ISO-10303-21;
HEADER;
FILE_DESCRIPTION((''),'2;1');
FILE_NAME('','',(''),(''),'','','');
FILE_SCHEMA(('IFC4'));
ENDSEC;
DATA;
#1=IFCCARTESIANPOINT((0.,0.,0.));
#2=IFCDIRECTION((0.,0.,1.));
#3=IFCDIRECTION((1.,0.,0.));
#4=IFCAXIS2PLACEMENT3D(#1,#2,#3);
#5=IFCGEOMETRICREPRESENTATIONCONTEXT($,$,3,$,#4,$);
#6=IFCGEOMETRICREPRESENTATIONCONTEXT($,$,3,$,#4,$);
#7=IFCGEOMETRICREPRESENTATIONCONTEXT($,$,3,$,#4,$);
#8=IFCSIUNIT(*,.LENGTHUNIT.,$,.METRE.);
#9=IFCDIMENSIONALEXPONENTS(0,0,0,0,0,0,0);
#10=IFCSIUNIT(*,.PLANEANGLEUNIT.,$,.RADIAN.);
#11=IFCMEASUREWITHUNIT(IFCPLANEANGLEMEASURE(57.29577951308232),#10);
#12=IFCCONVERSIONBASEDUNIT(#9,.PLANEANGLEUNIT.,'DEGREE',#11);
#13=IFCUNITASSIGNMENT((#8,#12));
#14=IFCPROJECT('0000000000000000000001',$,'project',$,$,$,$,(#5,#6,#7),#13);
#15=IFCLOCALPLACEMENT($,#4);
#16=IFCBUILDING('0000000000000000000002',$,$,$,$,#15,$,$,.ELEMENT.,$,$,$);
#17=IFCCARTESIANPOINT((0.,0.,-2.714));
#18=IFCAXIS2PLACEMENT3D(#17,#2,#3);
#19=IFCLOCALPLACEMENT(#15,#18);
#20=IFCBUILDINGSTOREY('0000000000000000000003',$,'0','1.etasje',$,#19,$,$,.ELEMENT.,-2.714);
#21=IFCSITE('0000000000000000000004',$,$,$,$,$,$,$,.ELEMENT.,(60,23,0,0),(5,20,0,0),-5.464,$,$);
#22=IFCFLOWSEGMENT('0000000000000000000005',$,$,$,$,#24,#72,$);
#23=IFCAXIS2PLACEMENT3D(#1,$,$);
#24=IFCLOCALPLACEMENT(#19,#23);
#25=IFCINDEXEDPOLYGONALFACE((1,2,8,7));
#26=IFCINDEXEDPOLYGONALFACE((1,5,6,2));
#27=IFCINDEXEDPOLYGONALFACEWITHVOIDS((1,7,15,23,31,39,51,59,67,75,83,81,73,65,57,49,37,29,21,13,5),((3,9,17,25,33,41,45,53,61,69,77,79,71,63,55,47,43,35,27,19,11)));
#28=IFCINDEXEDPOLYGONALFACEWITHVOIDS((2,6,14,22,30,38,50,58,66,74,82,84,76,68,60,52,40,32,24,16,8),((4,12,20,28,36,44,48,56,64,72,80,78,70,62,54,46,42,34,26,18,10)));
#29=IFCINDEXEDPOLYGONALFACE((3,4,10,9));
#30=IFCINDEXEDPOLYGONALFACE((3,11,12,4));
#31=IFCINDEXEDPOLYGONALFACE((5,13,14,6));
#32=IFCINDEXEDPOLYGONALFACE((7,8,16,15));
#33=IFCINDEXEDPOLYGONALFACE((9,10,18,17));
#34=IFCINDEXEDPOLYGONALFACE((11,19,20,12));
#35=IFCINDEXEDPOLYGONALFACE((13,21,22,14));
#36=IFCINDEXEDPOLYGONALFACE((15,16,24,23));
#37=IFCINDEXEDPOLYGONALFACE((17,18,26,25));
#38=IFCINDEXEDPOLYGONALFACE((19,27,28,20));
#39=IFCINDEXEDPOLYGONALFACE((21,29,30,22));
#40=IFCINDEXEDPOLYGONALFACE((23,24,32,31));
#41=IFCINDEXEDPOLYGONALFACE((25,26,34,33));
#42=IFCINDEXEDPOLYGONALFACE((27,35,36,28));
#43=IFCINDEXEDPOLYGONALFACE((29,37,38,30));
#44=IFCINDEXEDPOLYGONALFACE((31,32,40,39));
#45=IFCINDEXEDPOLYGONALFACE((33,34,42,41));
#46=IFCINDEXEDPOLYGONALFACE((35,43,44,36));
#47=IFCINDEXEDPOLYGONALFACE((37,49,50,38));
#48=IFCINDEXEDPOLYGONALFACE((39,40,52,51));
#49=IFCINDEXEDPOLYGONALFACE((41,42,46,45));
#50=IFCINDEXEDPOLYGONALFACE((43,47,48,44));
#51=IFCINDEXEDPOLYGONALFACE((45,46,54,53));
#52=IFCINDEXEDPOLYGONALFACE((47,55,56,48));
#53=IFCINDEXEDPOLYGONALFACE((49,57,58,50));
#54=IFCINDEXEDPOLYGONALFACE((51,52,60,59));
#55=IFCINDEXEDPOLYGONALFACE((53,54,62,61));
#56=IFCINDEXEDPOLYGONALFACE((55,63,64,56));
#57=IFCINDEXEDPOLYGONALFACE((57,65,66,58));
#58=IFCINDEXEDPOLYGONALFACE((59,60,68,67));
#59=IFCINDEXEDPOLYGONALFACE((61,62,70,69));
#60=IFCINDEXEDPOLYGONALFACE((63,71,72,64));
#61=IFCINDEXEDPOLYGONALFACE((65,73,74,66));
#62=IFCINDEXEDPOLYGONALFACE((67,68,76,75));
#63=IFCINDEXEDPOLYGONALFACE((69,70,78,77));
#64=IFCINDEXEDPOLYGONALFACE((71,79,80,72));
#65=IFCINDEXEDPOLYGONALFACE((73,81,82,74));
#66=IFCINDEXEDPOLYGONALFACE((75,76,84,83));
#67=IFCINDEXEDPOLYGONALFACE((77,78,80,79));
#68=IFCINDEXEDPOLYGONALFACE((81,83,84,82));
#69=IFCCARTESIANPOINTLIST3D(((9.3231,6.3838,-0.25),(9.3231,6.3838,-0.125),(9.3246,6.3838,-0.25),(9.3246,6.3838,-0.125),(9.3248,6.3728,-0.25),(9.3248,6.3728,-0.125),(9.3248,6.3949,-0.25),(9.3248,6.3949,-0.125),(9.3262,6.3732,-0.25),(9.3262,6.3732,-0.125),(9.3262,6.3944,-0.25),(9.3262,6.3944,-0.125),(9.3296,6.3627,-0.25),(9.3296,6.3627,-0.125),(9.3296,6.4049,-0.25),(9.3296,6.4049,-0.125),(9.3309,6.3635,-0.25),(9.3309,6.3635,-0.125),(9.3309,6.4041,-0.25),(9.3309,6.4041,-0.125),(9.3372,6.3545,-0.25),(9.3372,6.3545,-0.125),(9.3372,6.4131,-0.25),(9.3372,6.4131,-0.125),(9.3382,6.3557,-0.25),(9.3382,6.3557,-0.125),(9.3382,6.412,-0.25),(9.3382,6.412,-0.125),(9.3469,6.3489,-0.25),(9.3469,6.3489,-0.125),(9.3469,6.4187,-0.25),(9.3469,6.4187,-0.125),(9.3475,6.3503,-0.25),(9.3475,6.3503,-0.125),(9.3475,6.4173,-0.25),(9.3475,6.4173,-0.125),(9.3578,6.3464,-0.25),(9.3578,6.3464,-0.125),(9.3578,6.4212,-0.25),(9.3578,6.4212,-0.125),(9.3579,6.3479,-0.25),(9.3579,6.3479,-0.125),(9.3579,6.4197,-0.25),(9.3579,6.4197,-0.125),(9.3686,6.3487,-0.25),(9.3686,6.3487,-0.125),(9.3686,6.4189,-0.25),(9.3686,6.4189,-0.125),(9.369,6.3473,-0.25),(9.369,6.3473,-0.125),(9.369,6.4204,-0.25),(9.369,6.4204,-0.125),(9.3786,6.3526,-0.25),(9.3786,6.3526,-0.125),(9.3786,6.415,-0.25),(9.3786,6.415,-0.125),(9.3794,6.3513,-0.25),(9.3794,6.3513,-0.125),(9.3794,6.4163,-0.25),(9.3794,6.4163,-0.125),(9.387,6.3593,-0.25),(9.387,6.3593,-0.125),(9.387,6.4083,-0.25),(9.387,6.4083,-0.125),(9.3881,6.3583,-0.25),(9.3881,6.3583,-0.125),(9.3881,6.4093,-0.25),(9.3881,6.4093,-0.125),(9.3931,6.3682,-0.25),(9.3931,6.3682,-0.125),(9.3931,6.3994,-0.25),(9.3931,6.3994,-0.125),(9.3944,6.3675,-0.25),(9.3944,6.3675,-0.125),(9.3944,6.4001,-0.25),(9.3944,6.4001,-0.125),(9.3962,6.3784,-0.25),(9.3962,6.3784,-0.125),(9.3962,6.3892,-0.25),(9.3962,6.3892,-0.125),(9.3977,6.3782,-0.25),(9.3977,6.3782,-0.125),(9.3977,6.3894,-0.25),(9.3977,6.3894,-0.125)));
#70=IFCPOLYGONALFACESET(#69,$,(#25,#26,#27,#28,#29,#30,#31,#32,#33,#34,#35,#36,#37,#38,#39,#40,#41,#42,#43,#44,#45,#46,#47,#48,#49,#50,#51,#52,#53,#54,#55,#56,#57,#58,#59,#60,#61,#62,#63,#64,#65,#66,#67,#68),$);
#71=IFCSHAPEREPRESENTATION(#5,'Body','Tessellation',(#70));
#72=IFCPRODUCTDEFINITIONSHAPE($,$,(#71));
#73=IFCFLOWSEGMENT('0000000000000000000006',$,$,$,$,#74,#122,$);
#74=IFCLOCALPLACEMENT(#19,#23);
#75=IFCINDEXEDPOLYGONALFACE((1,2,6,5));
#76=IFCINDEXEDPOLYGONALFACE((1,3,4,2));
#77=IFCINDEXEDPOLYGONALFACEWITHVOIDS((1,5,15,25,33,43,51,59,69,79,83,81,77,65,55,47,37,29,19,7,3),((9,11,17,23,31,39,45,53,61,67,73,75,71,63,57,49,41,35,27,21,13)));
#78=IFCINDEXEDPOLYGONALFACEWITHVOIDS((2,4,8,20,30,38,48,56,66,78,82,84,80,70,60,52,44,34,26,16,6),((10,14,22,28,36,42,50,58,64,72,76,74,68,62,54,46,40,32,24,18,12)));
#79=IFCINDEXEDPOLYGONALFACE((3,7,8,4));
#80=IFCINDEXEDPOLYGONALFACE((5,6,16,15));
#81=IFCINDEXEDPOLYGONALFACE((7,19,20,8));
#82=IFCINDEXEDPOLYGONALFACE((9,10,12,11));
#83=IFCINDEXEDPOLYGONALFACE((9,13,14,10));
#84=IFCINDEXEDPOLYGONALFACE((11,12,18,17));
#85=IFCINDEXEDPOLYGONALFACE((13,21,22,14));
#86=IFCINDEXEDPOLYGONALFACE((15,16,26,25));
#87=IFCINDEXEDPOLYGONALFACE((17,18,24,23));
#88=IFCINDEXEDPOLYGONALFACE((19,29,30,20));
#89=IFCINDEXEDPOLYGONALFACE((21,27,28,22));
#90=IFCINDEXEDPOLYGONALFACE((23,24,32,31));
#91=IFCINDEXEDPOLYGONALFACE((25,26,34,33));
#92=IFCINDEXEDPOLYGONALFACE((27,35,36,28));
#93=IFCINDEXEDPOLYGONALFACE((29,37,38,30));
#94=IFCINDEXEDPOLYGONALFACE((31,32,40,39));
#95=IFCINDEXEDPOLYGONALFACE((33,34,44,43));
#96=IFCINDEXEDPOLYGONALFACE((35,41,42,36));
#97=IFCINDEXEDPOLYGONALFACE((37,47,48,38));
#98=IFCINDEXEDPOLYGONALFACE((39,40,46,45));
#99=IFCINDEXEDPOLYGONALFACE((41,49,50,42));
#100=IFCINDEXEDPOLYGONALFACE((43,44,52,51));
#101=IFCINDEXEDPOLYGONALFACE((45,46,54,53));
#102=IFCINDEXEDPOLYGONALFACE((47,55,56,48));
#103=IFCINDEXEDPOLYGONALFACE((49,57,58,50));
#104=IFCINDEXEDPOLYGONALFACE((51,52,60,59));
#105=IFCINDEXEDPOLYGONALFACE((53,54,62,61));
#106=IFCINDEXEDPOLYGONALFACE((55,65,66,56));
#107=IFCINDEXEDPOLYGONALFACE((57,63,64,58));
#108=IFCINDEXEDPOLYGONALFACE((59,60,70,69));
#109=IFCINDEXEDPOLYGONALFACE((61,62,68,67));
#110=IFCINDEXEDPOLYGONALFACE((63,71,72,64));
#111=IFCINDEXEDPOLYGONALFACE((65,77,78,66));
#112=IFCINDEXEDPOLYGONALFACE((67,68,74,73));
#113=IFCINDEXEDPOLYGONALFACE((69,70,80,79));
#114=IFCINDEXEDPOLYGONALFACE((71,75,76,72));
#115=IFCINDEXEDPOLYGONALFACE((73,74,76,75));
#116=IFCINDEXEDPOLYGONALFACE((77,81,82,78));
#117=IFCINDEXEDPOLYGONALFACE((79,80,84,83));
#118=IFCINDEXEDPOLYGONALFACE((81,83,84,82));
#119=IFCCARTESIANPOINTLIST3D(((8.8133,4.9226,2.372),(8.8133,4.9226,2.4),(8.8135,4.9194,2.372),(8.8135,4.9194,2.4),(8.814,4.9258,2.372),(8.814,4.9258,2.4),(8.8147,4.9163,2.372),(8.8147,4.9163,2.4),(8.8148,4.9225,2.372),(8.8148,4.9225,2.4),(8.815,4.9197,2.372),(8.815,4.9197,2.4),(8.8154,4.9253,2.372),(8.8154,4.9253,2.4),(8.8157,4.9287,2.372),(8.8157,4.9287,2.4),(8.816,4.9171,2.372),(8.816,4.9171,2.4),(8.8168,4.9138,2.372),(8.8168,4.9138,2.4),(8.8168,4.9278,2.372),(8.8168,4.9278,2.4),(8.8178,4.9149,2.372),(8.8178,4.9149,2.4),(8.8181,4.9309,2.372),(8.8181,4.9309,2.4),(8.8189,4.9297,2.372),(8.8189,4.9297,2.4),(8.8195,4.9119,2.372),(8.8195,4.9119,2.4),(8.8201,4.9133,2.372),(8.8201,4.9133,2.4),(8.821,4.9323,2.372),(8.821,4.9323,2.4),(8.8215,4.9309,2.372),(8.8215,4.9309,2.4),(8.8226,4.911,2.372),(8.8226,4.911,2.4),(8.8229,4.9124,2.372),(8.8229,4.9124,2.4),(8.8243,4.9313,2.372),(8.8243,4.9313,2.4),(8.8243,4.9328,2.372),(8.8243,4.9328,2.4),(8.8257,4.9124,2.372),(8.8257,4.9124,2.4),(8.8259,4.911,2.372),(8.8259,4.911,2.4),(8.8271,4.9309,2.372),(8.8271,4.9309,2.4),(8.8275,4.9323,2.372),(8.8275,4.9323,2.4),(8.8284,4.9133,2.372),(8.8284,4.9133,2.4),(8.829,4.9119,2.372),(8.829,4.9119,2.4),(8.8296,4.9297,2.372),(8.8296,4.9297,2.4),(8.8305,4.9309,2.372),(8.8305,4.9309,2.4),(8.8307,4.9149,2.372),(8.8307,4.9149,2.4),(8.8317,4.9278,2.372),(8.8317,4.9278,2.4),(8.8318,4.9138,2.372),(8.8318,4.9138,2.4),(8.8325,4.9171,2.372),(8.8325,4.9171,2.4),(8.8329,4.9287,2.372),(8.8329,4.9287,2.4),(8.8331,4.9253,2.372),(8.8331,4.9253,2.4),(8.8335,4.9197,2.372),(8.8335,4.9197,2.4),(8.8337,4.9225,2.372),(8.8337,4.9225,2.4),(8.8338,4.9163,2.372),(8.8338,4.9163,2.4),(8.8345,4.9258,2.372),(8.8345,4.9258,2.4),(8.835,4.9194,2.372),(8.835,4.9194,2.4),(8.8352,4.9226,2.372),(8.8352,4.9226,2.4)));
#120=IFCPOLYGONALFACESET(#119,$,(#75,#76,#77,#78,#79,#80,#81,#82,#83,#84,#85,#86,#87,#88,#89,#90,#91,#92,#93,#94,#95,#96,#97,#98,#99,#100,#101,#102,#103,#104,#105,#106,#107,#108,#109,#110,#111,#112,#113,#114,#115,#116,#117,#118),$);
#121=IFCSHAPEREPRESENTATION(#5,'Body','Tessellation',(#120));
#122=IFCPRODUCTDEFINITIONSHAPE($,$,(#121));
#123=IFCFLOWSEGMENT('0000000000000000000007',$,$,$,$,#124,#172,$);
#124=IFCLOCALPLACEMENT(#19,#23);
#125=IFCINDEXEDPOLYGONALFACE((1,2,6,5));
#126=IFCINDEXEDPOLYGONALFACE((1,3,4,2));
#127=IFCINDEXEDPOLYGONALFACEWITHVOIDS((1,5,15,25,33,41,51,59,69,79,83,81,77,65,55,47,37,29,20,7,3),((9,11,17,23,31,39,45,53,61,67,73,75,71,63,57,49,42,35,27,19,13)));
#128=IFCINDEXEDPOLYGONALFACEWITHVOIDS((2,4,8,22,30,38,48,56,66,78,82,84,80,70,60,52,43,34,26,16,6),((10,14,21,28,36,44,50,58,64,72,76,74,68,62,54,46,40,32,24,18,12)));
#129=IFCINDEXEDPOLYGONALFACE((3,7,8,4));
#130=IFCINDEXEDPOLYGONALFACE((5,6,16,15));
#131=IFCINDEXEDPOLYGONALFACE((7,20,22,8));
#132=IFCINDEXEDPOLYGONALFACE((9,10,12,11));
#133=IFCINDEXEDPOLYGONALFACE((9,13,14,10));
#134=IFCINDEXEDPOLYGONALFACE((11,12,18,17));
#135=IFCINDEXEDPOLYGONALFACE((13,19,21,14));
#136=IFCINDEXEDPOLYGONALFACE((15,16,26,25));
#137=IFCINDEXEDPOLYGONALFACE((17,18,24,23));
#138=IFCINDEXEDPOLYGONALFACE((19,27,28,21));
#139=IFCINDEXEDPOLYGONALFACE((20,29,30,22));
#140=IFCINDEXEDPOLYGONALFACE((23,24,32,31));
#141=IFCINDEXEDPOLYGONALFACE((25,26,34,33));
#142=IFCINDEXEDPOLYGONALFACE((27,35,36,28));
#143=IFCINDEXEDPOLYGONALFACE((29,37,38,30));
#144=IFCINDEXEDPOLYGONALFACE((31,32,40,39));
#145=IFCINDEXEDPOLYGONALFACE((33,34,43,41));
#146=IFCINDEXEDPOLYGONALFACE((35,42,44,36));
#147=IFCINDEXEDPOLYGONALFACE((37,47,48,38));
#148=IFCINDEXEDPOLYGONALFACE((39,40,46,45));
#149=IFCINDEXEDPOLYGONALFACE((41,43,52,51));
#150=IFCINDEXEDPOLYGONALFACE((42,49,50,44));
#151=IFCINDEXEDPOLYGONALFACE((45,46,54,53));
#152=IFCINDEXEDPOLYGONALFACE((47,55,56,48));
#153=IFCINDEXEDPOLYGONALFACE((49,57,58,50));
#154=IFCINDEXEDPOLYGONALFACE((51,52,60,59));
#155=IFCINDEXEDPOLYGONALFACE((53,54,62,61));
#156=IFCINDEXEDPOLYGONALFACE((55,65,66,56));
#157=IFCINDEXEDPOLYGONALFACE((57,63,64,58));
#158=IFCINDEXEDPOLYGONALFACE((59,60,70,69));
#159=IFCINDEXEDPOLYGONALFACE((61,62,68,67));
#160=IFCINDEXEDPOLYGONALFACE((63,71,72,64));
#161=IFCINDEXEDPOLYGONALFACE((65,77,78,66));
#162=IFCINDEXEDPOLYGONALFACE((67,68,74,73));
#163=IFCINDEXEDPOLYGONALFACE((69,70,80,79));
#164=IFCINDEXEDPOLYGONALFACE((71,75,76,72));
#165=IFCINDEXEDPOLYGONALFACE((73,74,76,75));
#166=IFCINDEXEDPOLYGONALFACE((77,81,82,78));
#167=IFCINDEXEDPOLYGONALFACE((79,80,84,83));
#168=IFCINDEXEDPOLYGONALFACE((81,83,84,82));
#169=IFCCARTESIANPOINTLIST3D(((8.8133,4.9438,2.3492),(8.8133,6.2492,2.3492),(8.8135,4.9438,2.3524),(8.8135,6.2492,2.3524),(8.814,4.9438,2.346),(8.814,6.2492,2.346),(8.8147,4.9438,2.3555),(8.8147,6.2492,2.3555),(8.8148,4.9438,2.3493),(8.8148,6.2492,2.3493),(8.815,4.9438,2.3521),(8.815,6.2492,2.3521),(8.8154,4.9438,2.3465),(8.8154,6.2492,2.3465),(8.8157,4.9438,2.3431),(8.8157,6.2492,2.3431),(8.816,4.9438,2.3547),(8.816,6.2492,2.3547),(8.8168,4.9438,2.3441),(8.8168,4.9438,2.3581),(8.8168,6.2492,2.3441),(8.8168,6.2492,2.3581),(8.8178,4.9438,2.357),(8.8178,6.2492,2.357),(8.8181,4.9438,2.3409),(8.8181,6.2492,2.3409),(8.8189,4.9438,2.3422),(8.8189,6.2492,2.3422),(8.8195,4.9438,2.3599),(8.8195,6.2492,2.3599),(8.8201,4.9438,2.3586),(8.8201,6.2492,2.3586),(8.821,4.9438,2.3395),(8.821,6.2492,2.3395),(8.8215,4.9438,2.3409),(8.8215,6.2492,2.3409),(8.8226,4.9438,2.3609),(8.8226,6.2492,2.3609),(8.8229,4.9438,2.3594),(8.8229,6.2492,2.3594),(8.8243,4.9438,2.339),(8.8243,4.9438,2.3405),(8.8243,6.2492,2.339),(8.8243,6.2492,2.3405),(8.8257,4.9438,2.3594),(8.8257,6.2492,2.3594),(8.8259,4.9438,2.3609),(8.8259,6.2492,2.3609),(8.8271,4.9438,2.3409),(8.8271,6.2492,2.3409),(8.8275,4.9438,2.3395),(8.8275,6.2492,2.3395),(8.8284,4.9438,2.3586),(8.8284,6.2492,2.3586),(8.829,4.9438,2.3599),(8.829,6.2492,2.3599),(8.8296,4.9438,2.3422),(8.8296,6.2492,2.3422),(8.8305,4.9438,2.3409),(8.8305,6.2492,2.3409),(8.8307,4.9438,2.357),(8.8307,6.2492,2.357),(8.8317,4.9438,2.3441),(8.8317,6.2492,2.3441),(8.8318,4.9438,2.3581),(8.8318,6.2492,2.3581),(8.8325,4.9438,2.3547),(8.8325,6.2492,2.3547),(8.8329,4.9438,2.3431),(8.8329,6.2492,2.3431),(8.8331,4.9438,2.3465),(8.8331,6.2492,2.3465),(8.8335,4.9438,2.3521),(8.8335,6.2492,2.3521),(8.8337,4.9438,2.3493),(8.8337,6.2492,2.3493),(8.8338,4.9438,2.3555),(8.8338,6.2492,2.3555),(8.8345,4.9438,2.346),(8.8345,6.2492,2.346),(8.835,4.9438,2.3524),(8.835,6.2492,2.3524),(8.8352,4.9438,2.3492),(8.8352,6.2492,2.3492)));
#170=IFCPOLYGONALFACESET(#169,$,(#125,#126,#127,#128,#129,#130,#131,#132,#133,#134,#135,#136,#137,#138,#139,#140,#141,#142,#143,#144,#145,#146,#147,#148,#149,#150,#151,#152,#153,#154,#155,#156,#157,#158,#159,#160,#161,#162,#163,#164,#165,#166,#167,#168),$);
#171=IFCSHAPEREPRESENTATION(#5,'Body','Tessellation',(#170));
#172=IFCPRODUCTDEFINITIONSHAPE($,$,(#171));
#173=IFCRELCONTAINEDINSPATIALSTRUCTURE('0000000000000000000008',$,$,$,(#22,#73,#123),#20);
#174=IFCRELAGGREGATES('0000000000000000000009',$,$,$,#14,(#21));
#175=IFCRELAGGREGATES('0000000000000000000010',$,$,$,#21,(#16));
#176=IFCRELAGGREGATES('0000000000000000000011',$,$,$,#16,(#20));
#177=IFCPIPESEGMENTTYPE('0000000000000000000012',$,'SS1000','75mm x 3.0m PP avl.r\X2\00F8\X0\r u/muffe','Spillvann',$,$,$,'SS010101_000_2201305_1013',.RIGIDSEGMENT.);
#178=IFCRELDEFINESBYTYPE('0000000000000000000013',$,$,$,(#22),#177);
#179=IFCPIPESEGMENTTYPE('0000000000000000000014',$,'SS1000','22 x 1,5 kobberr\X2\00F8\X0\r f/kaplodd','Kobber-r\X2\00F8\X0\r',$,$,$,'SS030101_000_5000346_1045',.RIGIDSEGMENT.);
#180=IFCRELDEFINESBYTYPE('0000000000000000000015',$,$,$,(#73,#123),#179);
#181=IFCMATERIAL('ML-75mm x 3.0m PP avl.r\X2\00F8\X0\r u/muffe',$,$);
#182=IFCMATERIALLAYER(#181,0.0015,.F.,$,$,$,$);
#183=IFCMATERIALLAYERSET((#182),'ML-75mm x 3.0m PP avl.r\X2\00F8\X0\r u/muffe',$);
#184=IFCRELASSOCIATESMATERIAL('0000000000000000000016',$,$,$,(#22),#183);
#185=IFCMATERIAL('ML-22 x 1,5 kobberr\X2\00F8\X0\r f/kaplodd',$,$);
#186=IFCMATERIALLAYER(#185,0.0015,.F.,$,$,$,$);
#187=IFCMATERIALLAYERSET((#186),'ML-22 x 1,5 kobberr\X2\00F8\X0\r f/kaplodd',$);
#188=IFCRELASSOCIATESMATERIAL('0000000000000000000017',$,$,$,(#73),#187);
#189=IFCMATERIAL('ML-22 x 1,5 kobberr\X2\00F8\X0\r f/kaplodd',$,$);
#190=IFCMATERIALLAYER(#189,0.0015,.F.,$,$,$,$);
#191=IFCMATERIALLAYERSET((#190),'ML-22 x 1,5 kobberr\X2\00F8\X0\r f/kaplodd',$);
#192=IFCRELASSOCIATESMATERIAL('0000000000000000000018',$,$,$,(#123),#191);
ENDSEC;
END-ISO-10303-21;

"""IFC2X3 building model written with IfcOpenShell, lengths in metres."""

from ifc_helpers import new_model, entity, si_unit, converted_unit, frame, origin_with_axes, origin_2d_with_axis, place, context, project, spatial, hollow_circle, extrude, material, layer, layer_set, layer_usage, type_object, element, save


model = new_model("IFC2X3")

# Units and contexts
context_of_model_1 = context(None, 3, world=origin_with_axes())
context_of_model_2 = context(None, 3, world=origin_with_axes())
context_of_model_3 = context(None, 3, world=origin_with_axes())
ifc_project = project(units=[si_unit("LENGTHUNIT", "METRE"), converted_unit("PLANEANGLEUNIT", "DEGREE", entity("IfcPlaneAngleMeasure", 57.29577951308232), si_unit("PLANEANGLEUNIT", "RADIAN"), dimensions=[0, 0, 0, 0, 0, 0, 0])], contexts=[context_of_model_1, context_of_model_2, context_of_model_3])

# Site, building, storey
site = spatial("IfcSite", under=ifc_project, CompositionType="ELEMENT", RefLatitude=(60, 23, 0, 0), RefLongitude=(5, 20, 0, 0), RefElevation=-5.464)
building_placement = place(None, origin_with_axes())
building = spatial("IfcBuilding", under=site, at=building_placement, CompositionType="ELEMENT")
storey_placement = place(building_placement, frame((0.0, 0.0, -2.714), z_axis=(0.0, 0.0, 1.0), x_axis=(1.0, 0.0, 0.0)))
storey = spatial("IfcBuildingStorey", under=building, at=storey_placement, Name="0", Description="1.etasje", CompositionType="ELEMENT", Elevation=-2.714)

# Flow segments
pipe_segment_type_1 = type_object("IfcPipeSegmentType", Name="SS1000", Description="75mm x 3.0m PP avl.rør u/muffe", ApplicableOccurrence="Spillvann", ElementType="SS010101_000_2201305_1013", PredefinedType="RIGIDSEGMENT")
ifc_material_1 = material(Name="ML-75mm x 3.0m PP avl.rør u/muffe")
ifc_layer_1 = layer(ifc_material_1, 0.0015, ventilated=False)
ifc_layer_set_1 = layer_set([ifc_layer_1], Name="ML-75mm x 3.0m PP avl.rør u/muffe")
ifc_layer_usage_1 = layer_usage(ifc_layer_set_1, "AXIS2", "POSITIVE", 0.0)
flow_segment_1_placement = place(storey_placement, frame((9.3606, 6.3838, -0.125), z_axis=(0.0, 0.0, -1.0), x_axis=(-1.0, 0.0, 0.0)))
element("IfcFlowSegment", 1, at=flow_segment_1_placement, inside=storey, type_object=pipe_segment_type_1, material=ifc_layer_usage_1, context=context_of_model_1, shape_type="SweptSolid", body=[
    extrude(hollow_circle(Radius=0.0375, WallThickness=0.0015, at=origin_2d_with_axis()), origin_with_axes(), (0.0, 0.0, 1.0), 0.125),
])
ifc_material_2 = material(Name="ML-22 x 1,5 kobberrør f/kaplodd")
ifc_layer_2 = layer(ifc_material_2, 0.0015, ventilated=False)
ifc_layer_set_2 = layer_set([ifc_layer_2], Name="ML-22 x 1,5 kobberrør f/kaplodd")
ifc_layer_usage_2 = layer_usage(ifc_layer_set_2, "AXIS2", "POSITIVE", 0.0)
pipe_segment_type_2 = type_object("IfcPipeSegmentType", Name="SS1000", Description="22 x 1,5 kobberrør f/kaplodd", ApplicableOccurrence="Kobber-rør", ElementType="SS030101_000_5000346_1045", PredefinedType="RIGIDSEGMENT")
flow_segment_2_placement = place(storey_placement, frame((8.8243, 4.9218, 2.4), z_axis=(0.0, 0.0, -1.0), x_axis=(0.0, 1.0, 0.0)))
element("IfcFlowSegment", 2, at=flow_segment_2_placement, inside=storey, type_object=pipe_segment_type_2, material=ifc_layer_usage_2, context=context_of_model_1, shape_type="SweptSolid", body=[
    extrude(hollow_circle(Radius=0.011, WallThickness=0.0015, at=origin_2d_with_axis()), origin_with_axes(), (0.0, 0.0, 1.0), 0.028),
])
ifc_material_3 = material(Name="ML-22 x 1,5 kobberrør f/kaplodd")
ifc_layer_3 = layer(ifc_material_3, 0.0015, ventilated=False)
ifc_layer_set_3 = layer_set([ifc_layer_3], Name="ML-22 x 1,5 kobberrør f/kaplodd")
ifc_layer_usage_3 = layer_usage(ifc_layer_set_3, "AXIS2", "POSITIVE", 0.0)
flow_segment_3_placement = place(storey_placement, frame((8.8243, 4.9438, 2.35), z_axis=(0.0, 1.0, 0.0), x_axis=(0.0, 0.0, -1.0)))
element("IfcFlowSegment", 3, at=flow_segment_3_placement, inside=storey, type_object=pipe_segment_type_2, material=ifc_layer_usage_3, context=context_of_model_1, shape_type="SweptSolid", body=[
    extrude(hollow_circle(Radius=0.011, WallThickness=0.0015, at=origin_2d_with_axis()), origin_with_axes(), (0.0, 0.0, 1.0), 1.3054),
])

save(model, "model.ifc")
